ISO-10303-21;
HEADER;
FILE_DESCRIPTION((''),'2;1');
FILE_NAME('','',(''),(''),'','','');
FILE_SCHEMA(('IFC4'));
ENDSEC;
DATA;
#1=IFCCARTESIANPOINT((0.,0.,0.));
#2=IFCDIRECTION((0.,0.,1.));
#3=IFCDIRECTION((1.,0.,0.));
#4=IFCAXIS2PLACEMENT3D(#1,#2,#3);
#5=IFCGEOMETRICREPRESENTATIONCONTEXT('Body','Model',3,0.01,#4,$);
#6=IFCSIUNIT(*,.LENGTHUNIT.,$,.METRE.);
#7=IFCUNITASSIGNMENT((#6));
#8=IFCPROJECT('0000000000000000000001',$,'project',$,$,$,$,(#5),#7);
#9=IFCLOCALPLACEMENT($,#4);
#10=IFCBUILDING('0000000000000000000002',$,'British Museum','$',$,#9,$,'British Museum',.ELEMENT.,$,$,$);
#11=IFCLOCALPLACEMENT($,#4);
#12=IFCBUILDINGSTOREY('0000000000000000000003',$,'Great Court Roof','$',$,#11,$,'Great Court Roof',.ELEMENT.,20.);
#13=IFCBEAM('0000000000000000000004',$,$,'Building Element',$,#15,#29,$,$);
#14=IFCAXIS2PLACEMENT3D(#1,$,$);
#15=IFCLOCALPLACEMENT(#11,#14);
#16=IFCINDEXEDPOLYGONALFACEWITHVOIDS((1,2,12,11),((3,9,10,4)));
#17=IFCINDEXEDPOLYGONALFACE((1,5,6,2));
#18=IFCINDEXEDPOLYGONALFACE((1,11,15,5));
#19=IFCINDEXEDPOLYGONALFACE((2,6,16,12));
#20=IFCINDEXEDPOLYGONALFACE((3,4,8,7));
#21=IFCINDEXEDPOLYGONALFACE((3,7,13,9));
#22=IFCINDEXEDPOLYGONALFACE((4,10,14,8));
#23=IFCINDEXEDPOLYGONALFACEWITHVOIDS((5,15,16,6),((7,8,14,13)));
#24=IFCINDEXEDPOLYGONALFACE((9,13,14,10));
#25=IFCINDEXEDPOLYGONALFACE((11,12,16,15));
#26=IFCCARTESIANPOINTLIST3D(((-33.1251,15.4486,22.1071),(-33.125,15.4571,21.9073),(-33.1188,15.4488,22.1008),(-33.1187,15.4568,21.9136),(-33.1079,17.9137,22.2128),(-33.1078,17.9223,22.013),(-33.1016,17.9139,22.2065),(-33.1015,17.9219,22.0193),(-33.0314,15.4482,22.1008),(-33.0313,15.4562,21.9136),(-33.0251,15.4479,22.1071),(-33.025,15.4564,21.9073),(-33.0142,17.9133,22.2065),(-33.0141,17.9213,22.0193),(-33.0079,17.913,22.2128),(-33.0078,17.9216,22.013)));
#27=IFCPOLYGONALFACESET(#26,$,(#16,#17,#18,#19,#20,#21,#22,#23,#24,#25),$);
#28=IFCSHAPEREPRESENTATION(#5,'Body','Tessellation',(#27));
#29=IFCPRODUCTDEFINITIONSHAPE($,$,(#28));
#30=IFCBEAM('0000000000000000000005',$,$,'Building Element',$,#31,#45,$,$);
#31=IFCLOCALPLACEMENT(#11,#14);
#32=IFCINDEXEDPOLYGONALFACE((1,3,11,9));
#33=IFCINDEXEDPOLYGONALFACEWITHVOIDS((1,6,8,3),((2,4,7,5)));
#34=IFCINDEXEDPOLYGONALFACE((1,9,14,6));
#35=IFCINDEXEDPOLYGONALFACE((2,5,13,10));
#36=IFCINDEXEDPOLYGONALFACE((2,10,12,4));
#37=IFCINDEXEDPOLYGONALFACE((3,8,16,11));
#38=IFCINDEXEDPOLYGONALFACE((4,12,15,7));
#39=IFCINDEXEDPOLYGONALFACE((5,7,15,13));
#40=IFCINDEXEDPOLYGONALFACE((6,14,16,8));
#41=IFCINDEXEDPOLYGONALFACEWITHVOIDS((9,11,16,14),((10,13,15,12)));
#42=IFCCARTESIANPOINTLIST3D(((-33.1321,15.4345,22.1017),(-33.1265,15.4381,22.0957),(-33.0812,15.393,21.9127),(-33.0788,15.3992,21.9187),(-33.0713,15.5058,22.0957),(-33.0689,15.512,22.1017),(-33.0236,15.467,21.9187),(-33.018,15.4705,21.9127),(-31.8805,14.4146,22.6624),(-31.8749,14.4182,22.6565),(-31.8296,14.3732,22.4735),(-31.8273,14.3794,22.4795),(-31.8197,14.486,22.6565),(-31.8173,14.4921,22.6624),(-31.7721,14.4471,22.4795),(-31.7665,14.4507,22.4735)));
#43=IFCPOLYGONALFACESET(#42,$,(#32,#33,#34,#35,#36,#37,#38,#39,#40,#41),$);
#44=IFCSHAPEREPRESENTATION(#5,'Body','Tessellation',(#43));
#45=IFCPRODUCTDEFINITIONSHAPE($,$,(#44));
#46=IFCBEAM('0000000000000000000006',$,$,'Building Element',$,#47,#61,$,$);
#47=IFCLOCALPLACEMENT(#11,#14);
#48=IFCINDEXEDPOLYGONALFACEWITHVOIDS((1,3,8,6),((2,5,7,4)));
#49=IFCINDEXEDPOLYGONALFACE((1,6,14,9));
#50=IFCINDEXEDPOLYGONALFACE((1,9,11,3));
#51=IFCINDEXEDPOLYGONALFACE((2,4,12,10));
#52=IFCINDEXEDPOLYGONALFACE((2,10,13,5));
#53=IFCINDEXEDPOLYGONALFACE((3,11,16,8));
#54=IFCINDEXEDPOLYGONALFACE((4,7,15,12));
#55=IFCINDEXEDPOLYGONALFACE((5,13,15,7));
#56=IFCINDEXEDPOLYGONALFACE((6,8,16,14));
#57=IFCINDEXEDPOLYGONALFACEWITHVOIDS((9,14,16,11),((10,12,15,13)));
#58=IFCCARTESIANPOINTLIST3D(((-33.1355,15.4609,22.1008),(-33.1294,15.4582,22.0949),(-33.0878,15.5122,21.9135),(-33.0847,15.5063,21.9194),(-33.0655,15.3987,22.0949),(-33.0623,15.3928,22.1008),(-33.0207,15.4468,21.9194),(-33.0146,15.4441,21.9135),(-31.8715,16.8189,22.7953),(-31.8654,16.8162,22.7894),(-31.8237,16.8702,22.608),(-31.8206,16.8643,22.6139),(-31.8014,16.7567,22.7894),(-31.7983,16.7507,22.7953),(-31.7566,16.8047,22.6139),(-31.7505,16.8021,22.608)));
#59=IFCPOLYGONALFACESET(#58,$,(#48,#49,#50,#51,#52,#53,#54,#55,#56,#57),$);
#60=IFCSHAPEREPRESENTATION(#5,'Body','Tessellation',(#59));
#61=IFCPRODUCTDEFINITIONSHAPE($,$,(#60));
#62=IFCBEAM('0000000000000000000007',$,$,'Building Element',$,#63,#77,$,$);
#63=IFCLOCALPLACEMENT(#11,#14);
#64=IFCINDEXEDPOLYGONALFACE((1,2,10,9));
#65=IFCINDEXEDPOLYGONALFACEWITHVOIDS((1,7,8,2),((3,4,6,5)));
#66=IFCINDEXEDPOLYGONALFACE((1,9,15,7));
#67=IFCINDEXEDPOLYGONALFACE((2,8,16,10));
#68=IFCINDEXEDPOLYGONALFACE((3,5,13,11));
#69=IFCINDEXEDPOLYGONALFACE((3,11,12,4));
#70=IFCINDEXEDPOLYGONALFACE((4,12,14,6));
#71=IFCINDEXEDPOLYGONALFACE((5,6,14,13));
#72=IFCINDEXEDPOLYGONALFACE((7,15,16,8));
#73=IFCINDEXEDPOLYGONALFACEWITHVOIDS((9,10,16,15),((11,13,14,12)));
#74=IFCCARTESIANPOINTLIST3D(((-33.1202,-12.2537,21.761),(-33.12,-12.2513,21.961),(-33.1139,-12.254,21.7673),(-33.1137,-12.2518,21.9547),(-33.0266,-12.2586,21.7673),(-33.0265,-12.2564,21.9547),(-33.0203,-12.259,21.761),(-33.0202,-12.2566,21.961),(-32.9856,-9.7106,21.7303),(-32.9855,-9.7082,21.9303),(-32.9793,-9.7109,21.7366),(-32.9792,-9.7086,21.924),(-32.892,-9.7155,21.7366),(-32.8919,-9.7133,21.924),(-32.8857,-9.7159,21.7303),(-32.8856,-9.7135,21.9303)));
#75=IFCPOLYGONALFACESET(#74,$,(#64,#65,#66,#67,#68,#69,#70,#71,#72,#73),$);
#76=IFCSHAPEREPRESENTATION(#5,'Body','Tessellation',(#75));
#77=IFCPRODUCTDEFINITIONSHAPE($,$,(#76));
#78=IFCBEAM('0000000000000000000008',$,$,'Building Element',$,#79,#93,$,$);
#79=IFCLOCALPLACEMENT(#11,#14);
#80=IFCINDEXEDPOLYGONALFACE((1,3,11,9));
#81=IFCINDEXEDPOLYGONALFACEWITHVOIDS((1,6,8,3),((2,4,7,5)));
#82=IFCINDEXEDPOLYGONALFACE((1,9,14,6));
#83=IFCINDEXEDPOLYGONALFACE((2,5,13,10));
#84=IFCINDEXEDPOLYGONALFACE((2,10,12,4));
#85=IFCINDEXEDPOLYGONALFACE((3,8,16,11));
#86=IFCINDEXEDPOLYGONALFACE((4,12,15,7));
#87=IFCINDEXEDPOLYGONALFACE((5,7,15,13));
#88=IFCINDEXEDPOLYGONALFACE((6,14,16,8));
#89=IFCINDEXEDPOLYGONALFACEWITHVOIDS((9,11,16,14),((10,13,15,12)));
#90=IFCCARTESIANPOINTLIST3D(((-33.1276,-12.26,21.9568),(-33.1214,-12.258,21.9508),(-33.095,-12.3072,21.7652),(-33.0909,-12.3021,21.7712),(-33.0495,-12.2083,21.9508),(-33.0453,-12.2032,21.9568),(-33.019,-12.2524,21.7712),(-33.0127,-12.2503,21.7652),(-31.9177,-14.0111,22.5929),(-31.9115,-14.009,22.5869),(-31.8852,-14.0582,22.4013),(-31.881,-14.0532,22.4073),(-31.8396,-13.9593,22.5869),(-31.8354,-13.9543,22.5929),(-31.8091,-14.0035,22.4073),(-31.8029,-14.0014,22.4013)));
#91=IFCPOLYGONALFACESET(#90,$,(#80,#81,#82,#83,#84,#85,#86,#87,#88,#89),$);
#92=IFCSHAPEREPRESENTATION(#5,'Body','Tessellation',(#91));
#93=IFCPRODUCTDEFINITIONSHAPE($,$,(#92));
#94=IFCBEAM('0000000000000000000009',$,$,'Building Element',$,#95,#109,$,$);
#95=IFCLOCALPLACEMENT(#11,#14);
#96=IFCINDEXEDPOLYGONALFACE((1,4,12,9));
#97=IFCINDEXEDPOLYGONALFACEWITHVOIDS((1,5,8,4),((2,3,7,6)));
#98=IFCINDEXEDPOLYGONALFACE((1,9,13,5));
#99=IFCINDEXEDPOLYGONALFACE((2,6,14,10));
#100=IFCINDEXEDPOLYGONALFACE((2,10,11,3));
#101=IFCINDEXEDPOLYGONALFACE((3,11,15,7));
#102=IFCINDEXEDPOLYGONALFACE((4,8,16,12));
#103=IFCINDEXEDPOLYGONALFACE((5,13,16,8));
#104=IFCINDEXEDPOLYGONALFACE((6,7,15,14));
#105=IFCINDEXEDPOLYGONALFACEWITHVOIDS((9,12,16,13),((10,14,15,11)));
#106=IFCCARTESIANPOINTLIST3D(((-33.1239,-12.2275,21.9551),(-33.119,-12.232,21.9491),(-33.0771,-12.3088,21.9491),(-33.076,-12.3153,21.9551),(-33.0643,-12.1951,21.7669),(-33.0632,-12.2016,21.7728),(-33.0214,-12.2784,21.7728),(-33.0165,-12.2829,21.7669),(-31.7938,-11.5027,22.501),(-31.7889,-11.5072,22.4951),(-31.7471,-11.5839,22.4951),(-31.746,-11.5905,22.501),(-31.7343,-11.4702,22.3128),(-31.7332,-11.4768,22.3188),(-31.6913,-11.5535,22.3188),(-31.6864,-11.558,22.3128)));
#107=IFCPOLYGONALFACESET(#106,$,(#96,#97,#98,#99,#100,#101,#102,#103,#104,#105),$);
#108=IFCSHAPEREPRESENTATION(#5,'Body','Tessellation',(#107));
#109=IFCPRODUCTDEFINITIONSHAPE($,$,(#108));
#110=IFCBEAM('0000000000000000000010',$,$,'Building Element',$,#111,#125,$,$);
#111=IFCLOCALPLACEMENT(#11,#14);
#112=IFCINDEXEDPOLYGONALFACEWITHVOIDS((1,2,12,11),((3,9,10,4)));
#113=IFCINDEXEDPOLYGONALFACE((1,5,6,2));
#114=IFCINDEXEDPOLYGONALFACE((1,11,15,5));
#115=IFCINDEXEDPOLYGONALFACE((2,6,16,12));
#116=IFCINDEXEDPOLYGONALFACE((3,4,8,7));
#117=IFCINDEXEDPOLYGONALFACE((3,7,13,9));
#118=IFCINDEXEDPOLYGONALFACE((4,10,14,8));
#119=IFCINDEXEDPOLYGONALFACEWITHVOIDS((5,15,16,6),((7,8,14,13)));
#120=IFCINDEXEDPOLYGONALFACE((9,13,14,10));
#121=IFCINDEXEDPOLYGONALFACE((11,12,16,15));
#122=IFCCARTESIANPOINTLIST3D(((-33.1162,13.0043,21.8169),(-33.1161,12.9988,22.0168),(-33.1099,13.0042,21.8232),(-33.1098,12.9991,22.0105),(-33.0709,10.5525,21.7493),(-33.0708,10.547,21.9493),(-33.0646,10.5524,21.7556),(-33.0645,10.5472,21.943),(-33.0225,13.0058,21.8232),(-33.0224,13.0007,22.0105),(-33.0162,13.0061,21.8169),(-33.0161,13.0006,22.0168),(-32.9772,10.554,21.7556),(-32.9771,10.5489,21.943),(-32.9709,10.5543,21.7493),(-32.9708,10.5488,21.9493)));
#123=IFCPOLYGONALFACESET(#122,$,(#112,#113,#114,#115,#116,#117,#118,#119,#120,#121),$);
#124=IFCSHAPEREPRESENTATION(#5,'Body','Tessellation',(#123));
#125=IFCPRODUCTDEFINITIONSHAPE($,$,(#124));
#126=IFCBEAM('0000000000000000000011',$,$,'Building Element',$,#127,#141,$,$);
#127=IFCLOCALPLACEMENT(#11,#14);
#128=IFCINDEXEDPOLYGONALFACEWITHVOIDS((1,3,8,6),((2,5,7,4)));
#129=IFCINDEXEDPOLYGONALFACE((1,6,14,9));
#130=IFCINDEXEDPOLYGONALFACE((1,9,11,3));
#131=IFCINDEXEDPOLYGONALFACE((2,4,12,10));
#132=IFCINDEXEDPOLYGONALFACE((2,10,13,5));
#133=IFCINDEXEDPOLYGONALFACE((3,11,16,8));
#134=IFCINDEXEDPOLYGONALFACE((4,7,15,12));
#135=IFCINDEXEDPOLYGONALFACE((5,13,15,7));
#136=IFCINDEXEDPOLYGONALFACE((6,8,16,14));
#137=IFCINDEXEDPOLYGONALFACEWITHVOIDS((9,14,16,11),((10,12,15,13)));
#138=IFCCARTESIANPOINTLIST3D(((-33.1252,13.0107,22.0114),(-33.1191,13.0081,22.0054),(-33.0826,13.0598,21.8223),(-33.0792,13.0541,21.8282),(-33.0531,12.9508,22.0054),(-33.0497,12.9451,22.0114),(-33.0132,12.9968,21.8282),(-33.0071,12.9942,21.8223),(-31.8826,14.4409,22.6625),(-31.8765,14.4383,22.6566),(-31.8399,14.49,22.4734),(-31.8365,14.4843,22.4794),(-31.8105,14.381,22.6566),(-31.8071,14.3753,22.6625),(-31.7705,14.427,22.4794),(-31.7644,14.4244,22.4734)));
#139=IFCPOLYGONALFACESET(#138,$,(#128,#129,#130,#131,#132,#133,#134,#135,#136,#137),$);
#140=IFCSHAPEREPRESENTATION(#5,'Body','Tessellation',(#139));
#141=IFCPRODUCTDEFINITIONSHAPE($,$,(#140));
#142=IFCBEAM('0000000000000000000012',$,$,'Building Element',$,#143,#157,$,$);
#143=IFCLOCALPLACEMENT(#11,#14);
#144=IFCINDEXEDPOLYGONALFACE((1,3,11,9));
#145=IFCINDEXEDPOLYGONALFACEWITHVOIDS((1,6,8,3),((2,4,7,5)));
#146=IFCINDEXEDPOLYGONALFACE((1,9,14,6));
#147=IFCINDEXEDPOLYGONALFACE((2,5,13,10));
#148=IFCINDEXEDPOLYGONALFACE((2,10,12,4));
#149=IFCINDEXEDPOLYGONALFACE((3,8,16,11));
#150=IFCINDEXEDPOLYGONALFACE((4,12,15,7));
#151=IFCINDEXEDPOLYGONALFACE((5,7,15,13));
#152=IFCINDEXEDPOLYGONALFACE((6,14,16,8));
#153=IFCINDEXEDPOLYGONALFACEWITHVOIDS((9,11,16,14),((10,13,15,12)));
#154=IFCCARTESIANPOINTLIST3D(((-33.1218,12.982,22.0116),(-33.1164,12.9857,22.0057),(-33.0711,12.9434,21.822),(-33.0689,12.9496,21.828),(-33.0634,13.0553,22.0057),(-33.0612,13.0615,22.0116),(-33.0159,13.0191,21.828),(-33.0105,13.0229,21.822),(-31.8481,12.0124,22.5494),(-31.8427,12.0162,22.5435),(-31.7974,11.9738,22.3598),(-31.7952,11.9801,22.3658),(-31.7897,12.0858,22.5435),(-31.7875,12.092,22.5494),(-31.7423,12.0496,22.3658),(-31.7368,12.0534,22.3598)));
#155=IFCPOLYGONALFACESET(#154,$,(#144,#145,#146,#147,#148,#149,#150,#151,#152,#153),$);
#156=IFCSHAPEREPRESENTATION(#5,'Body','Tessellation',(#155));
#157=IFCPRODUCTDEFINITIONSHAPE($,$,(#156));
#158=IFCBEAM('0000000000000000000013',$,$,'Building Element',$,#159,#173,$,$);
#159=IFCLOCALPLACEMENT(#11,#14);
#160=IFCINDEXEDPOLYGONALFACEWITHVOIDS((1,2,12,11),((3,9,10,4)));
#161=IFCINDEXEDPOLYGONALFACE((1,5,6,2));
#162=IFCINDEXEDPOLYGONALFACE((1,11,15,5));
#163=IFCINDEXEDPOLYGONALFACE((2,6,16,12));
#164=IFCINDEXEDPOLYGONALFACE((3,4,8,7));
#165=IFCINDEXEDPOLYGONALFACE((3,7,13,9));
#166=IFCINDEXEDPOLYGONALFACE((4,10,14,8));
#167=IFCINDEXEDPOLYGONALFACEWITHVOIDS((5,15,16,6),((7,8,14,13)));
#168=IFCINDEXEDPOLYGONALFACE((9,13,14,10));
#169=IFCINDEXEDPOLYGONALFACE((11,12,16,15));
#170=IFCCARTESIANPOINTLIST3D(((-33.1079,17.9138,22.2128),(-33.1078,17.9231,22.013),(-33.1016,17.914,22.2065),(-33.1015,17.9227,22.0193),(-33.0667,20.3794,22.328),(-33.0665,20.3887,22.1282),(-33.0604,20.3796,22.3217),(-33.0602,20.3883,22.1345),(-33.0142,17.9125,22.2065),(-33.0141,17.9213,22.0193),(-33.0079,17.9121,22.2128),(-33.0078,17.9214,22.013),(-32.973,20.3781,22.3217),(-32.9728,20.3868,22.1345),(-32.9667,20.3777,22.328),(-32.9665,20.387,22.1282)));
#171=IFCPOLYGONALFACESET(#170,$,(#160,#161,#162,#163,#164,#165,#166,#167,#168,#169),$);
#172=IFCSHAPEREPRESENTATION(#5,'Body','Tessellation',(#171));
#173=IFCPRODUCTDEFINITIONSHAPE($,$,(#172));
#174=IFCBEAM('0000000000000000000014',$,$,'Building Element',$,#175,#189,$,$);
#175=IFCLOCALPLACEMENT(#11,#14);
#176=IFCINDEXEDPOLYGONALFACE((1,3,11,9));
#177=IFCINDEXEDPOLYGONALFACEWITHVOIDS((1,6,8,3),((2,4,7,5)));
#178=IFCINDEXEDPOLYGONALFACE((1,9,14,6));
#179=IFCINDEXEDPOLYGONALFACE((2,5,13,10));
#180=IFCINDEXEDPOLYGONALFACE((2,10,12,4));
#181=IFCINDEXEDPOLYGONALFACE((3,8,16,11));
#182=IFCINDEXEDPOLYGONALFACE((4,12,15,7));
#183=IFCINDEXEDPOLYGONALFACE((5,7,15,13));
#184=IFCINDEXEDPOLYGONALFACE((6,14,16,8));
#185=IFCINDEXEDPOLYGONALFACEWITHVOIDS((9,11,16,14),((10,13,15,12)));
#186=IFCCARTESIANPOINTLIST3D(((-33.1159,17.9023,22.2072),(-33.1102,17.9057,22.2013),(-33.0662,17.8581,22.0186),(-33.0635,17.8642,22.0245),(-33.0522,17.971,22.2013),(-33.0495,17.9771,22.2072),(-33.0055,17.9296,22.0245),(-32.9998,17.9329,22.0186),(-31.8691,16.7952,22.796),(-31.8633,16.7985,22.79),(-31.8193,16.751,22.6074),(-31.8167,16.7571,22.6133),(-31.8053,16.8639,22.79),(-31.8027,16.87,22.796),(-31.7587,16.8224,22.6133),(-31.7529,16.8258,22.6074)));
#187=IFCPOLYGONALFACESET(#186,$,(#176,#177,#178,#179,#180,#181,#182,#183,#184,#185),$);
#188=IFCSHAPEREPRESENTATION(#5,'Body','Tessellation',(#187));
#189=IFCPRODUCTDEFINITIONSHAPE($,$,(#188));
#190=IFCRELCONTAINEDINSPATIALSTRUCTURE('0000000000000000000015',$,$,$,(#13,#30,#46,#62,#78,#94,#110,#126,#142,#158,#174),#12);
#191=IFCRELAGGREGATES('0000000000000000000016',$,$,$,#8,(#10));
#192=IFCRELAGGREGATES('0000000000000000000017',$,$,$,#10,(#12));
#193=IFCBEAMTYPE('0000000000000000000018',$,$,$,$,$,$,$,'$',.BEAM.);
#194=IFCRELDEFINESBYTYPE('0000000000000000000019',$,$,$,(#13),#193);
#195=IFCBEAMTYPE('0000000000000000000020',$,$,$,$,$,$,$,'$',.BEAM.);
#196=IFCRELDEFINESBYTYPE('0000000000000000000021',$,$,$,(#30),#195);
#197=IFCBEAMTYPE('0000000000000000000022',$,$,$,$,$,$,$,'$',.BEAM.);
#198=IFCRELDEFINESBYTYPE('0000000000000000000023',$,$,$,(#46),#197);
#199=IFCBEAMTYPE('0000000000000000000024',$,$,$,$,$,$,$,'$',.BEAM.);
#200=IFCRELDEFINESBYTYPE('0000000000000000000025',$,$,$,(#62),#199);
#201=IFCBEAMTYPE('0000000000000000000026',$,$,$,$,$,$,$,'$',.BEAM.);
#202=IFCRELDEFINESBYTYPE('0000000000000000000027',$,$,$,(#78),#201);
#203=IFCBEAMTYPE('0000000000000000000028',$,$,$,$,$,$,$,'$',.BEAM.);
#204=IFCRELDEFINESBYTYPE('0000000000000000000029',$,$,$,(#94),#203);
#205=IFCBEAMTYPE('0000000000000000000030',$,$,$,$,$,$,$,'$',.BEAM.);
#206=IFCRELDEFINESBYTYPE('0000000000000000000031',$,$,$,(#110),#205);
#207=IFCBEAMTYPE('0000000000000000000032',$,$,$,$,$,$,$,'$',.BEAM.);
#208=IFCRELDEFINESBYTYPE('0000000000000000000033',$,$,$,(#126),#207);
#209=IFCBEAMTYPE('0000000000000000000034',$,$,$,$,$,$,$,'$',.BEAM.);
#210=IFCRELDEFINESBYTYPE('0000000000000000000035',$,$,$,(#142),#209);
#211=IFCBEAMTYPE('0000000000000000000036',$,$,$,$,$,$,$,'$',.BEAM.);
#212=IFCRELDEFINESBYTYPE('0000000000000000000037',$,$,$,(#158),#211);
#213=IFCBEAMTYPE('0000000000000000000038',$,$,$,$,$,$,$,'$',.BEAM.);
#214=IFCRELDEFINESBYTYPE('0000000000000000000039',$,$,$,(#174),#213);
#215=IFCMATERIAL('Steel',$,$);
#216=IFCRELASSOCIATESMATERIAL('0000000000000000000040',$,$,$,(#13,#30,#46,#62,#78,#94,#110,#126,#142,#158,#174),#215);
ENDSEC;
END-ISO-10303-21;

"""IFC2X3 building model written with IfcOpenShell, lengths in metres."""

from ifc_helpers import new_model, si_unit, frame, origin_with_axes, origin_2d, place, context, project, spatial, hollow_rectangle, extrude, material, type_object, element, save


model = new_model("IFC2X3")

# Units and contexts
model_context = context("Model", 3, precision=0.01, world=origin_with_axes(), identifier="Body")
ifc_project = project(units=[si_unit("LENGTHUNIT", "METRE")], contexts=[model_context])

# Building, storey
building_placement = place(None, origin_with_axes())
building = spatial("IfcBuilding", under=ifc_project, at=building_placement, Name="British Museum", Description="$", LongName="British Museum", CompositionType="ELEMENT")
storey_placement = place(None, origin_with_axes())
storey = spatial("IfcBuildingStorey", under=building, at=storey_placement, Name="Great Court Roof", Description="$", LongName="Great Court Roof", CompositionType="ELEMENT", Elevation=20.0)

# Beams
ifc_material = material(Name="Steel")
beam_type_1 = type_object("IfcBeamType", ElementType="$", PredefinedType="BEAM")
beam_1_placement = place(None, origin_with_axes())
element("IfcBeam", 1, at=beam_1_placement, inside=storey, type_object=beam_type_1, material=ifc_material, Description="Building Element", context=model_context, shape_type="SweptSolid", body=[
    extrude(hollow_rectangle(XDim=0.1, YDim=0.2, WallThickness=0.0063, InnerFilletRadius=0.0, OuterFilletRadius=0.0, at=origin_2d()), frame((-33.0751, 15.4525, 22.0072), z_axis=(0.006974, 0.999057, 0.042843), x_axis=(-0.999976, 0.00698, 0.0)), (0.0, 0.0, 1.0), 2.4674),
])
beam_type_2 = type_object("IfcBeamType", ElementType="$", PredefinedType="BEAM")
beam_2_placement = place(None, origin_with_axes())
element("IfcBeam", 2, at=beam_2_placement, inside=storey, type_object=beam_type_2, material=ifc_material, Description="Building Element", context=model_context, shape_type="SweptSolid", body=[
    extrude(hollow_rectangle(XDim=0.1, YDim=0.2, WallThickness=0.0063, InnerFilletRadius=0.0, OuterFilletRadius=0.0, at=origin_2d()), frame((-33.0751, 15.4525, 22.0072), z_axis=(0.732296, -0.596723, 0.328121), x_axis=(0.631697, 0.775215, 0.0)), (0.0, 0.0, 1.0), 1.7091),
])
beam_type_3 = type_object("IfcBeamType", ElementType="$", PredefinedType="BEAM")
beam_3_placement = place(None, origin_with_axes())
element("IfcBeam", 3, at=beam_3_placement, inside=storey, type_object=beam_type_3, material=ifc_material, Description="Building Element", context=model_context, shape_type="SweptSolid", body=[
    extrude(hollow_rectangle(XDim=0.1, YDim=0.2, WallThickness=0.0063, InnerFilletRadius=0.0, OuterFilletRadius=0.0, at=origin_2d()), frame((-33.0751, 15.4525, 22.0072), z_axis=(0.638103, 0.685509, 0.350574), x_axis=(-0.731963, 0.681344, 0.0)), (0.0, 0.0, 1.0), 1.981),
])
beam_type_4 = type_object("IfcBeamType", ElementType="$", PredefinedType="BEAM")
beam_4_placement = place(None, origin_with_axes())
element("IfcBeam", 4, at=beam_4_placement, inside=storey, type_object=beam_type_4, material=ifc_material, Description="Building Element", context=model_context, shape_type="SweptSolid", body=[
    extrude(hollow_rectangle(XDim=0.1, YDim=0.2, WallThickness=0.0063, InnerFilletRadius=0.0, OuterFilletRadius=0.0, at=origin_2d()), frame((-33.0702, -12.2552, 21.861), z_axis=(0.052829, 0.998531, -0.012033), x_axis=(-0.998603, 0.052833, 0.0)), (0.0, 0.0, 1.0), 2.5468),
])
beam_type_5 = type_object("IfcBeamType", ElementType="$", PredefinedType="BEAM")
beam_5_placement = place(None, origin_with_axes())
element("IfcBeam", 5, at=beam_5_placement, inside=storey, type_object=beam_type_5, material=ifc_material, Description="Building Element", context=model_context, shape_type="SweptSolid", body=[
    extrude(hollow_rectangle(XDim=0.1, YDim=0.2, WallThickness=0.0063, InnerFilletRadius=0.0, OuterFilletRadius=0.0, at=origin_2d()), frame((-33.0702, -12.2552, 21.861), z_axis=(0.544633, -0.788273, 0.286357), x_axis=(0.822727, 0.568437, 0.0)), (0.0, 0.0, 1.0), 2.2214),
])
beam_type_6 = type_object("IfcBeamType", ElementType="$", PredefinedType="BEAM")
beam_6_placement = place(None, origin_with_axes())
element("IfcBeam", 6, at=beam_6_placement, inside=storey, type_object=beam_type_6, material=ifc_material, Description="Building Element", context=model_context, shape_type="SweptSolid", body=[
    extrude(hollow_rectangle(XDim=0.1, YDim=0.2, WallThickness=0.0063, InnerFilletRadius=0.0, OuterFilletRadius=0.0, at=origin_2d()), frame((-33.0702, -12.2552, 21.861), z_axis=(0.82605, 0.450195, 0.339065), x_axis=(-0.478542, 0.878065, 0.0)), (0.0, 0.0, 1.0), 1.6101),
])
beam_type_7 = type_object("IfcBeamType", ElementType="$", PredefinedType="BEAM")
beam_7_placement = place(None, origin_with_axes())
element("IfcBeam", 7, at=beam_7_placement, inside=storey, type_object=beam_type_7, material=ifc_material, Description="Building Element", context=model_context, shape_type="SweptSolid", body=[
    extrude(hollow_rectangle(XDim=0.1, YDim=0.2, WallThickness=0.0063, InnerFilletRadius=0.0, OuterFilletRadius=0.0, at=origin_2d()), frame((-33.0662, 13.0024, 21.9168), z_axis=(0.018466, -0.99945, -0.027531), x_axis=(0.999829, 0.018473, 0.0)), (0.0, 0.0, 1.0), 2.4532),
])
beam_type_8 = type_object("IfcBeamType", ElementType="$", PredefinedType="BEAM")
beam_8_placement = place(None, origin_with_axes())
element("IfcBeam", 8, at=beam_8_placement, inside=storey, type_object=beam_type_8, material=ifc_material, Description="Building Element", context=model_context, shape_type="SweptSolid", body=[
    extrude(hollow_rectangle(XDim=0.1, YDim=0.2, WallThickness=0.0063, InnerFilletRadius=0.0, OuterFilletRadius=0.0, at=origin_2d()), frame((-33.0662, 13.0024, 21.9168), z_axis=(0.620269, 0.713883, 0.325017), x_axis=(-0.754867, 0.655878, 0.0)), (0.0, 0.0, 1.0), 2.0034),
])
beam_type_9 = type_object("IfcBeamType", ElementType="$", PredefinedType="BEAM")
beam_9_placement = place(None, origin_with_axes())
element("IfcBeam", 9, at=beam_9_placement, inside=storey, type_object=beam_type_9, material=ifc_material, Description="Building Element", context=model_context, shape_type="SweptSolid", body=[
    extrude(hollow_rectangle(XDim=0.1, YDim=0.2, WallThickness=0.0063, InnerFilletRadius=0.0, OuterFilletRadius=0.0, at=origin_2d()), frame((-33.0662, 13.0024, 21.9168), z_axis=(0.754271, -0.574144, 0.318486), x_axis=(0.605683, 0.795706, 0.0)), (0.0, 0.0, 1.0), 1.6886),
])
beam_type_10 = type_object("IfcBeamType", ElementType="$", PredefinedType="BEAM")
beam_10_placement = place(None, origin_with_axes())
element("IfcBeam", 10, at=beam_10_placement, inside=storey, type_object=beam_type_10, material=ifc_material, Description="Building Element", context=model_context, shape_type="SweptSolid", body=[
    extrude(hollow_rectangle(XDim=0.1, YDim=0.2, WallThickness=0.0063, InnerFilletRadius=0.0, OuterFilletRadius=0.0, at=origin_2d()), frame((-33.0579, 17.9176, 22.1129), z_axis=(0.016704, 0.998771, 0.046663), x_axis=(-0.99986, 0.016723, 0.0)), (0.0, 0.0, 1.0), 2.4686),
])
beam_type_11 = type_object("IfcBeamType", ElementType="$", PredefinedType="BEAM")
beam_11_placement = place(None, origin_with_axes())
element("IfcBeam", 11, at=beam_11_placement, inside=storey, type_object=beam_type_11, material=ifc_material, Description="Building Element", context=model_context, shape_type="SweptSolid", body=[
    extrude(hollow_rectangle(XDim=0.1, YDim=0.2, WallThickness=0.0063, InnerFilletRadius=0.0, OuterFilletRadius=0.0, at=origin_2d()), frame((-33.0579, 17.9176, 22.1129), z_axis=(0.705095, -0.62609, 0.332945), x_axis=(0.663972, 0.747757, 0.0)), (0.0, 0.0, 1.0), 1.7683),
])

save(model, "model.ifc")
